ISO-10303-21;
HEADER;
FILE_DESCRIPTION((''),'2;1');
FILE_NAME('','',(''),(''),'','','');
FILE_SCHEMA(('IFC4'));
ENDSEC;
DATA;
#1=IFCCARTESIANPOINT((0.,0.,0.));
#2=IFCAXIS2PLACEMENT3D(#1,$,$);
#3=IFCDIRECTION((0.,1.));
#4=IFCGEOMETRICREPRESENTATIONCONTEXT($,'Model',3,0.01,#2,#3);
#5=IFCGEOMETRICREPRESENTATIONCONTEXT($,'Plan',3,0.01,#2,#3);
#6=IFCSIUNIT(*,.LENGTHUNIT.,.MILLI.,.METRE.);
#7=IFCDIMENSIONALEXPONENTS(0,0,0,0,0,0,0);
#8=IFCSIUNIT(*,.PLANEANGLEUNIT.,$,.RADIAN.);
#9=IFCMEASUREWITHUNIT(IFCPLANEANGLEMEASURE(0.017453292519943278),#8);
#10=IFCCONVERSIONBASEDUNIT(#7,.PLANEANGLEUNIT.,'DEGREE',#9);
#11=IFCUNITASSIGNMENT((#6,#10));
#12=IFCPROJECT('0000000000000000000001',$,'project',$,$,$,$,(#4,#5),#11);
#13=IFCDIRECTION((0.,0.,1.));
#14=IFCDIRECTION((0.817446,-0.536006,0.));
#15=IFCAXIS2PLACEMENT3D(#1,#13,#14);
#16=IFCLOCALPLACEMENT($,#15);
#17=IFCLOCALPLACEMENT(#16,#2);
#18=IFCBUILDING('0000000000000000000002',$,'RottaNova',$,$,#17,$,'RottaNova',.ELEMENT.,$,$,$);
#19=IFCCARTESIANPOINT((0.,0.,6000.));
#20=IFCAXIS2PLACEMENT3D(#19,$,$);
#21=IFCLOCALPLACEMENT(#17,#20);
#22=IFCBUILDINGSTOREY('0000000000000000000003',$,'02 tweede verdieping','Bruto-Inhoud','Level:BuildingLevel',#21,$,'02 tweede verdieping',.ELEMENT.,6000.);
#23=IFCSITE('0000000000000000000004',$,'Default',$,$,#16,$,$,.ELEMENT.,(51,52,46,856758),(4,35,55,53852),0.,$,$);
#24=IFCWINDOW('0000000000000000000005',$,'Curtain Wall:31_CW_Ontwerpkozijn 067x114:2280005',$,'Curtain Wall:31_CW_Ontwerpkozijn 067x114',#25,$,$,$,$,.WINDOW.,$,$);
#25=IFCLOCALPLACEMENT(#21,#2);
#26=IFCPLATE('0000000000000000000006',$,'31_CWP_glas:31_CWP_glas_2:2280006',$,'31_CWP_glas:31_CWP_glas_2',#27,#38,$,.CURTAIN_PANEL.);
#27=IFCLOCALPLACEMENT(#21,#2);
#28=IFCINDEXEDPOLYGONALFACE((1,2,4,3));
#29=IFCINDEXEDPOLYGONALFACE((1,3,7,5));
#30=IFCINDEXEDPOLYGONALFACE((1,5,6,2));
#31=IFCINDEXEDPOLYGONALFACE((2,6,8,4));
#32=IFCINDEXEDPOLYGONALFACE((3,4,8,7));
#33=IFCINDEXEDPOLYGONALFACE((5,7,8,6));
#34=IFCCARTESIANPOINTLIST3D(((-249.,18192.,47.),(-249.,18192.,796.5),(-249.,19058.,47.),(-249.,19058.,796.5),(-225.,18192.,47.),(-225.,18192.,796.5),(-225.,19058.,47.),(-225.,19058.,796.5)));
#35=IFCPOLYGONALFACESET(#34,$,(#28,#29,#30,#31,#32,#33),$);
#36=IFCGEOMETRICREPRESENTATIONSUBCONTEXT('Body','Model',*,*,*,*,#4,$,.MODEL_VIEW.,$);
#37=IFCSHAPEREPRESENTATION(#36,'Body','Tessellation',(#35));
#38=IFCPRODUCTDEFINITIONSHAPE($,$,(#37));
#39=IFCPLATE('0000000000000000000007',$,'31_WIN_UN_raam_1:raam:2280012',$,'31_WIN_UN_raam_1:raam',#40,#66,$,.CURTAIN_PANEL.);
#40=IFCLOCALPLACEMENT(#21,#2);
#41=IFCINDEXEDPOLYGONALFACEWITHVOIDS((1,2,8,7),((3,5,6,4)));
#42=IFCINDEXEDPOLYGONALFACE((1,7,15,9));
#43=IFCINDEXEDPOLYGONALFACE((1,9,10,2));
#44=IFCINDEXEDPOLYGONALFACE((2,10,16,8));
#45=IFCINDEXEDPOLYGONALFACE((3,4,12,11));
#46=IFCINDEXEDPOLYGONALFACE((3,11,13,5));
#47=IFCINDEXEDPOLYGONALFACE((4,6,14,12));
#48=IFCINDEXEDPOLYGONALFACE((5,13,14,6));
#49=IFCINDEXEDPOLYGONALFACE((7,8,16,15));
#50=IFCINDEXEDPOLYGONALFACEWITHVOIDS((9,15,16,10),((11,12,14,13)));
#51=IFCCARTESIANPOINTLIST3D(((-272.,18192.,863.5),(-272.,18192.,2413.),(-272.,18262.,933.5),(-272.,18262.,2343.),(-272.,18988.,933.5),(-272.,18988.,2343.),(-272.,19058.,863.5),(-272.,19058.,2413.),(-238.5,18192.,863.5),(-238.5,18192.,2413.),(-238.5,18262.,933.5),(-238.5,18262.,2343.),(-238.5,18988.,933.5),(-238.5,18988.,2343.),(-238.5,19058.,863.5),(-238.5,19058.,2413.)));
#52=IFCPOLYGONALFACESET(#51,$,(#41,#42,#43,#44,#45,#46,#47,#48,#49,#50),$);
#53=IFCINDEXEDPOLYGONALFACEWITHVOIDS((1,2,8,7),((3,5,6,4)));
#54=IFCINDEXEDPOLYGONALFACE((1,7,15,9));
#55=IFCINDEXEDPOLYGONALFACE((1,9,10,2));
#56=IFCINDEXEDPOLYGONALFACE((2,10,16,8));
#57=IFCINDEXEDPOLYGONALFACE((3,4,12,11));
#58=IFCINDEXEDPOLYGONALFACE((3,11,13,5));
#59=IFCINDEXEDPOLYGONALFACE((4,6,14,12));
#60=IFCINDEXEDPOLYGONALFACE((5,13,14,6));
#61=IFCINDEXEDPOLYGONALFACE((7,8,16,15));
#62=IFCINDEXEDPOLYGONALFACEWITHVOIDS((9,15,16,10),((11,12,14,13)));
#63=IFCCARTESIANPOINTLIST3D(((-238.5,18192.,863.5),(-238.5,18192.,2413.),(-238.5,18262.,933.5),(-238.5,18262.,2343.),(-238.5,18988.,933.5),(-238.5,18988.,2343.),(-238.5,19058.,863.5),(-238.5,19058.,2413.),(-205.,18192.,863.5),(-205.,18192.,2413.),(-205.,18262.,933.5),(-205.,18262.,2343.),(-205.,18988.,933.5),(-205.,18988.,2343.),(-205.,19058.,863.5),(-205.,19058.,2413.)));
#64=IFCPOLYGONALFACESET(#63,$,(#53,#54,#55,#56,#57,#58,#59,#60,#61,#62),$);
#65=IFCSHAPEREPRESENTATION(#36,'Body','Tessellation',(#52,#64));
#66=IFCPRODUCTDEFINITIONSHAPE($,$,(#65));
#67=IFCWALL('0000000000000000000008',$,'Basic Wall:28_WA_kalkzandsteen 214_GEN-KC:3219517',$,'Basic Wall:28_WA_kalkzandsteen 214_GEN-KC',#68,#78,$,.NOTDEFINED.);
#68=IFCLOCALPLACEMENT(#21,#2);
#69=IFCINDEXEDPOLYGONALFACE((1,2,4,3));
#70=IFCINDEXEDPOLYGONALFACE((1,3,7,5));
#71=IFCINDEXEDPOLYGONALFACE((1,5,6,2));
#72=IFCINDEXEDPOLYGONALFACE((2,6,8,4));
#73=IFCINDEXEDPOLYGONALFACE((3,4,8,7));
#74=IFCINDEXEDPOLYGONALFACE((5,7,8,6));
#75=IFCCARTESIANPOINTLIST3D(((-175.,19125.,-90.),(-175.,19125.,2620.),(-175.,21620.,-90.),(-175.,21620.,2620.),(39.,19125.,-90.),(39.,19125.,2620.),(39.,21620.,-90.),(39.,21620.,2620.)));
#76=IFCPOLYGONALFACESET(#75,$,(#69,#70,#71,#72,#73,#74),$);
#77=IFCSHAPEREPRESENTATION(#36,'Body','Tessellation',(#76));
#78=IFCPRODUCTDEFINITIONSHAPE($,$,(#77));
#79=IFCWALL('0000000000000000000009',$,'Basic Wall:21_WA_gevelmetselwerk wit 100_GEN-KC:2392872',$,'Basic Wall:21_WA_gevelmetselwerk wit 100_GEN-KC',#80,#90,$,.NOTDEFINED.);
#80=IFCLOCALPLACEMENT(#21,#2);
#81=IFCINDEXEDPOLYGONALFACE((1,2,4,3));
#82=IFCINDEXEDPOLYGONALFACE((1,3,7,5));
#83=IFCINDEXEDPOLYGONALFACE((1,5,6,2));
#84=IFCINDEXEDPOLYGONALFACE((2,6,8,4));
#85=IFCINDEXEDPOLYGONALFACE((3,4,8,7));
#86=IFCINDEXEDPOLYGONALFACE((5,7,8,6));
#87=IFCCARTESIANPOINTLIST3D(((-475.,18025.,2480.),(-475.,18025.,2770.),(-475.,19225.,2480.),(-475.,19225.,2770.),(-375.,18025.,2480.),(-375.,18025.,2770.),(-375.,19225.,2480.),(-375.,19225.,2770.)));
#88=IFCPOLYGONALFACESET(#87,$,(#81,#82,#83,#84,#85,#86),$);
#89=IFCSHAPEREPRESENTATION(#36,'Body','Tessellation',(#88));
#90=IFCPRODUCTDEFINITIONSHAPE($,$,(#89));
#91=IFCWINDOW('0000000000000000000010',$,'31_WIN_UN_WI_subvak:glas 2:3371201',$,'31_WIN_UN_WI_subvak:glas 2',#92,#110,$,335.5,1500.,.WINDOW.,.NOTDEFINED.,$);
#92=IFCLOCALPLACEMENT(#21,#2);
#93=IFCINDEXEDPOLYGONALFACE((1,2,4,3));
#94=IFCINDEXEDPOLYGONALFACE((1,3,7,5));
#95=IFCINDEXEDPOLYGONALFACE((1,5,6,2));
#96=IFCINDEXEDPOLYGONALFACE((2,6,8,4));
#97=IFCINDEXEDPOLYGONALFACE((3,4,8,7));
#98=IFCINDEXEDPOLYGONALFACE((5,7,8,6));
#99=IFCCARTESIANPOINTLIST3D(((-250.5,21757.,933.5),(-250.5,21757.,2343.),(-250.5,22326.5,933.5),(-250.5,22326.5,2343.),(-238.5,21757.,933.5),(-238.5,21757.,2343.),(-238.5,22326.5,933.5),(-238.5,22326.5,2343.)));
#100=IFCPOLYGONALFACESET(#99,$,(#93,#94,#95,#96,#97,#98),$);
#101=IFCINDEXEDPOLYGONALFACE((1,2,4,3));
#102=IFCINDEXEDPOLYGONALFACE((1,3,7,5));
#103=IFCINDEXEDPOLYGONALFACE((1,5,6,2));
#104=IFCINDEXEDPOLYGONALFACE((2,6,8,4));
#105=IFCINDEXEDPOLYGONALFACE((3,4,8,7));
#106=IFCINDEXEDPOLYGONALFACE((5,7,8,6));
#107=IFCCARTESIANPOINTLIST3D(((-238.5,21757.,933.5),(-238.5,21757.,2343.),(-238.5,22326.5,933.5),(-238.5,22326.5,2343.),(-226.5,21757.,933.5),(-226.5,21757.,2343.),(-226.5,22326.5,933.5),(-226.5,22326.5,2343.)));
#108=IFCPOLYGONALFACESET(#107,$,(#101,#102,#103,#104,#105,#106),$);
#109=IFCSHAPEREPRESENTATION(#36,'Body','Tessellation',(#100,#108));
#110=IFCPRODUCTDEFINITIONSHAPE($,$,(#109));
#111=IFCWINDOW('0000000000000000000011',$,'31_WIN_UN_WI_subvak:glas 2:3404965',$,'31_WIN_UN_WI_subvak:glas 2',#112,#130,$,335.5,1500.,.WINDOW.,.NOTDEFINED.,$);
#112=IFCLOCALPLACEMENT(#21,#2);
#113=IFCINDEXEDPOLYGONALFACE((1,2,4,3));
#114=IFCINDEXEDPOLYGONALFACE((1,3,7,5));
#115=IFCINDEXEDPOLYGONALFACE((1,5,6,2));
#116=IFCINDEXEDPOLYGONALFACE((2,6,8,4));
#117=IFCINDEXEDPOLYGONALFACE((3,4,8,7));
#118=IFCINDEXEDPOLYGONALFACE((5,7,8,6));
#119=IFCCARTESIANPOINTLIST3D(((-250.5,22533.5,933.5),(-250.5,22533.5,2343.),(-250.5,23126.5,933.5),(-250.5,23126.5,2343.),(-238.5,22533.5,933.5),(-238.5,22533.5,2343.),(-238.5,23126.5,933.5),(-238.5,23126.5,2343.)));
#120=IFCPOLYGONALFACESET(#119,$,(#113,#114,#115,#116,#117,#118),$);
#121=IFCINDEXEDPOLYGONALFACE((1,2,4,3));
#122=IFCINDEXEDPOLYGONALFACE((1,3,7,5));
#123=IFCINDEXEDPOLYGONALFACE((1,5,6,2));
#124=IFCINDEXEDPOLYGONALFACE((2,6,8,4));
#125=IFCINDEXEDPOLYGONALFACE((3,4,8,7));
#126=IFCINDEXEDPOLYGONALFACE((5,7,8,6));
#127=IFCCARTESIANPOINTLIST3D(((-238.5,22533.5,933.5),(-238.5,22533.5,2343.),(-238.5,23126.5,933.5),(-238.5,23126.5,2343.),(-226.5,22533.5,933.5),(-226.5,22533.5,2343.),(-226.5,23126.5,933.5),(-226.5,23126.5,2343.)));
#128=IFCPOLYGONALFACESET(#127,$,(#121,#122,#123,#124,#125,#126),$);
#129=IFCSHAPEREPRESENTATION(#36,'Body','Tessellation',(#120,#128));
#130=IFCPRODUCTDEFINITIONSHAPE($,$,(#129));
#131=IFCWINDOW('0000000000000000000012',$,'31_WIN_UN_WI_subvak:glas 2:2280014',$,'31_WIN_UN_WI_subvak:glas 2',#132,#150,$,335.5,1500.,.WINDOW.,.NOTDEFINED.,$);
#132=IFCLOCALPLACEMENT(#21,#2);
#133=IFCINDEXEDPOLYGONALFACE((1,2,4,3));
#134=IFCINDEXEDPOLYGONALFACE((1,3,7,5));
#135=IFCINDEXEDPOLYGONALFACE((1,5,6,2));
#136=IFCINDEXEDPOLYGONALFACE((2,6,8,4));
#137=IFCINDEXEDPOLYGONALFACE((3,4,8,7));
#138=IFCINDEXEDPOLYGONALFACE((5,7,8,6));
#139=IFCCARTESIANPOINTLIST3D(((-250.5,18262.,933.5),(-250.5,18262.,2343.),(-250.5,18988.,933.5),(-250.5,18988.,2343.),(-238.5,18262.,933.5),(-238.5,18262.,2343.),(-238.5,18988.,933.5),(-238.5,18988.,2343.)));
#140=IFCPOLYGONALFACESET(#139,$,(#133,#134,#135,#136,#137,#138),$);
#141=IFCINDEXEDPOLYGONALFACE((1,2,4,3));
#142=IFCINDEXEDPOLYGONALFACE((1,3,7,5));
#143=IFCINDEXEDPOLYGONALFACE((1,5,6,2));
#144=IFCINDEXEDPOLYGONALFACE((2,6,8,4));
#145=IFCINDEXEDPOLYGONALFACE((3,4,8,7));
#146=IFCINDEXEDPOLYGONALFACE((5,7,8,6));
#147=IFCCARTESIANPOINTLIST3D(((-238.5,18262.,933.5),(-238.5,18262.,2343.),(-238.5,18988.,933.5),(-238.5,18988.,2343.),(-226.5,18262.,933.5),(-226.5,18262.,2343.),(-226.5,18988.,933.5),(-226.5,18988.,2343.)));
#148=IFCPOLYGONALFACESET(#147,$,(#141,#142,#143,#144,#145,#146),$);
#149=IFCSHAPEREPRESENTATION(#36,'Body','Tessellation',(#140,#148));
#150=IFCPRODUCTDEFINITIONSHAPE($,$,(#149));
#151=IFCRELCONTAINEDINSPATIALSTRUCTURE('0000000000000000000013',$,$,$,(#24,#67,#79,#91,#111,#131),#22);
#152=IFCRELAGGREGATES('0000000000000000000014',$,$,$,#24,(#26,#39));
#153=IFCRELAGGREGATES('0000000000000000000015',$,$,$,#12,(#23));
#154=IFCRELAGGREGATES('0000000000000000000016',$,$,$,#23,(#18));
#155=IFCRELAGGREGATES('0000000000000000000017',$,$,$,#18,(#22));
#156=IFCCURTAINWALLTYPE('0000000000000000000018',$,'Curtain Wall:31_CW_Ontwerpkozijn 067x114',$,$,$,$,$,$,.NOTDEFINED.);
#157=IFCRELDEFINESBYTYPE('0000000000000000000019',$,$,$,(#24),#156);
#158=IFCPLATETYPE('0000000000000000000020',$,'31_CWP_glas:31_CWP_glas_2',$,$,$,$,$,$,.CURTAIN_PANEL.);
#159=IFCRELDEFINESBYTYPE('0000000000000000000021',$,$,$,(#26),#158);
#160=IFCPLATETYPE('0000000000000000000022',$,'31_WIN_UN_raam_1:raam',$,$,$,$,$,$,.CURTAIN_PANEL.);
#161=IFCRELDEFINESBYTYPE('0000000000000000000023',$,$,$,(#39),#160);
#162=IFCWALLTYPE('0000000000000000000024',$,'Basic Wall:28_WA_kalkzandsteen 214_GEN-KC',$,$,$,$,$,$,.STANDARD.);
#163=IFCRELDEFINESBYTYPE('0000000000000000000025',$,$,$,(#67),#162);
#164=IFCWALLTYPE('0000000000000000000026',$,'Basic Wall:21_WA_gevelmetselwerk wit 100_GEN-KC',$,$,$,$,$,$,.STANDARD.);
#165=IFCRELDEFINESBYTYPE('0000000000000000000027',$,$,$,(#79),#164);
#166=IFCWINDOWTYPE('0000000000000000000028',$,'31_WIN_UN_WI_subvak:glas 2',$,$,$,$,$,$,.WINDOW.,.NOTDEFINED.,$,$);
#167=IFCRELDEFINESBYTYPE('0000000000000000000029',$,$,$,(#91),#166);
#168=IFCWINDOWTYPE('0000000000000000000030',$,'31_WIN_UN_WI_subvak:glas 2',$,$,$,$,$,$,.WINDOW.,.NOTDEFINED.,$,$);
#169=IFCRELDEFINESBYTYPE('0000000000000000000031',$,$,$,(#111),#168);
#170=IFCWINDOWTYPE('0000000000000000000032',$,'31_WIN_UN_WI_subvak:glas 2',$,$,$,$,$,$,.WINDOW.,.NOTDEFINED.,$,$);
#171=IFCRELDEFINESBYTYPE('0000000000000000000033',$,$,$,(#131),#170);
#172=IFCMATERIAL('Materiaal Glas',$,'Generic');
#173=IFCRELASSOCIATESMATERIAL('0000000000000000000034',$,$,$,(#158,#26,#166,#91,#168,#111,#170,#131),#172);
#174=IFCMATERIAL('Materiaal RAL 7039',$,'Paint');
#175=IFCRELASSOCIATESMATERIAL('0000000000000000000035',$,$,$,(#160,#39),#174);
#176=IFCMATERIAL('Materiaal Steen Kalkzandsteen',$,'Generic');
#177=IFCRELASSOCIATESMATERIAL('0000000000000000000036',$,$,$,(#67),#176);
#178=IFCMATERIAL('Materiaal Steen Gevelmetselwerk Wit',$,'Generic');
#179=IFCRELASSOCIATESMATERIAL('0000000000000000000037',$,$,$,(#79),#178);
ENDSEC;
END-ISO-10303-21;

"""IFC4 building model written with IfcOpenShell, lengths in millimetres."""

from ifc_helpers import new_model, entity, si_unit, converted_unit, direction, frame, origin, place, context, subcontext, project, spatial, indexed_curve, outline, extrude, source, transform, mapped, material, type_object, type_shapes, element, aggregate, save


model = new_model("IFC4")

# Units and contexts
model_context = context("Model", 3, precision=0.01, world=origin(), true_north=direction((0.0, 1.0)))
plan_context = context("Plan", 3, precision=0.01, world=origin(), true_north=direction((0.0, 1.0)))
body_context = subcontext(model_context, "Body", "Model", "MODEL_VIEW")
ifc_project = project(units=[si_unit("LENGTHUNIT", "METRE", prefix="MILLI"), converted_unit("PLANEANGLEUNIT", "DEGREE", entity("IfcPlaneAngleMeasure", 0.017453292519943278), si_unit("PLANEANGLEUNIT", "RADIAN"), dimensions=[0, 0, 0, 0, 0, 0, 0])], contexts=[model_context, plan_context])

# Site, building, storey
site_placement = place(None, frame((0.0, 0.0, 0.0), z_axis=(0.0, 0.0, 1.0), x_axis=(0.817446, -0.536006, 0.0)))
site = spatial("IfcSite", under=ifc_project, at=site_placement, Name="Default", CompositionType="ELEMENT", RefLatitude=(51, 52, 46, 856758), RefLongitude=(4, 35, 55, 53852), RefElevation=0.0)
building_placement = place(site_placement, origin())
building = spatial("IfcBuilding", under=site, at=building_placement, Name="RottaNova", LongName="RottaNova", CompositionType="ELEMENT")
storey_placement = place(building_placement, frame((0.0, 0.0, 6000.0)))
storey = spatial("IfcBuildingStorey", under=building, at=storey_placement, Name="02 tweede verdieping", Description="Bruto-Inhoud", ObjectType="Level:BuildingLevel", LongName="02 tweede verdieping", CompositionType="ELEMENT", Elevation=6000.0)

# Window
curtain_wall_type = type_object("IfcCurtainWallType", Name="Curtain Wall:31_CW_Ontwerpkozijn 067x114", PredefinedType="NOTDEFINED")
window_1_placement = place(storey_placement, frame((0.0, 0.0, -6000.0)))
window_1 = element("IfcWindow", 1, at=window_1_placement, inside=storey, type_object=curtain_wall_type, Name="Curtain Wall:31_CW_Ontwerpkozijn 067x114:2280005", ObjectType="Curtain Wall:31_CW_Ontwerpkozijn 067x114", PredefinedType="WINDOW")

# Plates
ifc_material_1 = material(Name="Materiaal Glas", Category="Generic")
ifc_material_2 = material(Name="Materiaal RAL 7039", Category="Paint")
plate_type_1 = type_object("IfcPlateType", Name="31_CWP_glas:31_CWP_glas_2", PredefinedType="CURTAIN_PANEL", material=ifc_material_1)
shared_shape_1 = source(origin(), body_context, "Body", "SweptSolid", [
    extrude(outline(indexed_curve([(-12.0, -433.0), (12.0, -433.0), (12.0, 433.0), (-12.0, 433.0), (-12.0, -433.0)], self_intersect=False)), frame((0.0, 57.0, 0.0), z_axis=(0.0, 0.0, 1.0), x_axis=(0.0, 1.0, 0.0)), (0.0, 0.0, 1.0), 749.5),
])
type_shapes(plate_type_1, [shared_shape_1])
plate_1_placement = place(window_1_placement, frame((-180.0, 18625.0, 6047.0), z_axis=(0.0, 0.0, 1.0), x_axis=(0.0, 1.0, 0.0)))
plate_1 = element("IfcPlate", 2, at=plate_1_placement, type_object=plate_type_1, material=ifc_material_1, Name="31_CWP_glas:31_CWP_glas_2:2280006", ObjectType="31_CWP_glas:31_CWP_glas_2", PredefinedType="CURTAIN_PANEL", context=body_context, shape_type="MappedRepresentation", body=[
    mapped(shared_shape_1, transform((0.0, 0.0, 0.0), scale=1.0)),
])
plate_type_2 = type_object("IfcPlateType", Name="31_WIN_UN_raam_1:raam", PredefinedType="CURTAIN_PANEL", material=ifc_material_2)
shared_shape_2 = source(origin(), body_context, "Body", "SweptSolid", [
    extrude(outline(indexed_curve([(-433.0, -774.7), (433.0, -774.7), (433.0, 774.7), (-433.0, 774.7), (-433.0, -774.7)], self_intersect=False), holes=[indexed_curve([(-363.0, 704.7), (363.0, 704.7), (363.0, -704.8), (-363.0, -704.8), (-363.0, 704.7)], self_intersect=False)]), frame((0.0, 58.5, 774.8), z_axis=(0.0, 1.0, 0.0), x_axis=(1.0, 0.0, 0.0)), (0.0, 0.0, 1.0), 33.5),
    extrude(outline(indexed_curve([(-433.0, -774.7), (433.0, -774.7), (433.0, 774.7), (-433.0, 774.7), (-433.0, -774.7)], self_intersect=False), holes=[indexed_curve([(-363.0, 704.7), (363.0, 704.7), (363.0, -704.8), (-363.0, -704.8), (-363.0, 704.7)], self_intersect=False)]), frame((0.0, 25.0, 774.8), z_axis=(0.0, 1.0, 0.0), x_axis=(1.0, 0.0, 0.0)), (0.0, 0.0, 1.0), 33.5),
])
type_shapes(plate_type_2, [shared_shape_2])
plate_2_placement = place(window_1_placement, frame((-180.0, 18625.0, 6863.5), z_axis=(0.0, 0.0, 1.0), x_axis=(0.0, 1.0, 0.0)))
plate_2 = element("IfcPlate", 3, at=plate_2_placement, type_object=plate_type_2, material=ifc_material_2, Name="31_WIN_UN_raam_1:raam:2280012", ObjectType="31_WIN_UN_raam_1:raam", PredefinedType="CURTAIN_PANEL", context=body_context, shape_type="MappedRepresentation", body=[
    mapped(shared_shape_2, transform((0.0, 0.0, 0.0), scale=1.0)),
])
aggregate(window_1, [plate_1, plate_2])

# Walls
ifc_material_3 = material(Name="Materiaal Steen Kalkzandsteen", Category="Generic")
wall_type_1 = type_object("IfcWallType", Name="Basic Wall:28_WA_kalkzandsteen 214_GEN-KC", PredefinedType="STANDARD")
wall_1_placement = place(storey_placement, frame((-68.0, 19125.0, -90.0), z_axis=(0.0, 0.0, 1.0), x_axis=(0.0, 1.0, 0.0)))
element("IfcWall", 4, at=wall_1_placement, inside=storey, type_object=wall_type_1, material=ifc_material_3, Name="Basic Wall:28_WA_kalkzandsteen 214_GEN-KC:3219517", ObjectType="Basic Wall:28_WA_kalkzandsteen 214_GEN-KC", PredefinedType="NOTDEFINED", context=body_context, shape_type="SweptSolid", body=[
    extrude(outline(indexed_curve([(2495.0, 107.0), (0.0, 107.0), (0.0, -107.0), (2495.0, -107.0), (2495.0, 107.0)], self_intersect=False)), origin(), (0.0, 0.0, 1.0), 2710.0),
])
ifc_material_4 = material(Name="Materiaal Steen Gevelmetselwerk Wit", Category="Generic")
wall_type_2 = type_object("IfcWallType", Name="Basic Wall:21_WA_gevelmetselwerk wit 100_GEN-KC", PredefinedType="STANDARD")
wall_2_placement = place(storey_placement, frame((-425.0, 19225.0, 2480.0), z_axis=(0.0, 0.0, 1.0), x_axis=(0.0, -1.0, 0.0)))
element("IfcWall", 5, at=wall_2_placement, inside=storey, type_object=wall_type_2, material=ifc_material_4, Name="Basic Wall:21_WA_gevelmetselwerk wit 100_GEN-KC:2392872", ObjectType="Basic Wall:21_WA_gevelmetselwerk wit 100_GEN-KC", PredefinedType="NOTDEFINED", context=body_context, shape_type="SweptSolid", body=[
    extrude(outline(indexed_curve([(1200.0, 50.0), (0.0, 50.0), (0.0, -50.0), (1200.0, -50.0), (1200.0, 50.0)], self_intersect=False)), origin(), (0.0, 0.0, 1.0), 290.0),
])

# Windows
window_type_1 = type_object("IfcWindowType", Name="31_WIN_UN_WI_subvak:glas 2", PartitioningType="NOTDEFINED", PredefinedType="WINDOW", material=ifc_material_1)
shared_shape_3 = source(origin(), body_context, "Body", "SweptSolid", [
    extrude(outline(indexed_curve([(-284.7, -6.0), (284.7, -6.0), (284.7, 6.0), (-284.7, 6.0), (-284.7, -6.0)], self_intersect=False)), frame((0.0, -6.0, 0.0)), (0.0, 0.0, 1.0), 1409.5),
    extrude(outline(indexed_curve([(-284.8, -6.0), (284.8, -6.0), (284.8, 6.0), (-284.8, 6.0), (-284.8, -6.0)], self_intersect=False)), frame((0.0, 6.0, 0.0)), (0.0, 0.0, 1.0), 1409.5),
])
type_shapes(window_type_1, [shared_shape_3])
window_2_placement = place(storey_placement, frame((-238.5, 22041.7, 933.5), z_axis=(0.0, 0.0, 1.0), x_axis=(0.0, -1.0, 0.0)))
element("IfcWindow", 6, at=window_2_placement, inside=storey, type_object=window_type_1, material=ifc_material_1, Name="31_WIN_UN_WI_subvak:glas 2:3371201", ObjectType="31_WIN_UN_WI_subvak:glas 2", OverallHeight=335.5, OverallWidth=1500.0, PartitioningType="NOTDEFINED", PredefinedType="WINDOW", context=body_context, shape_type="MappedRepresentation", body=[
    mapped(shared_shape_3, transform((0.0, 0.0, 0.0), scale=1.0)),
])
window_type_2 = type_object("IfcWindowType", Name="31_WIN_UN_WI_subvak:glas 2", PartitioningType="NOTDEFINED", PredefinedType="WINDOW", material=ifc_material_1)
shared_shape_4 = source(origin(), body_context, "Body", "SweptSolid", [
    extrude(outline(indexed_curve([(-296.5, -6.0), (296.5, -6.0), (296.5, 6.0), (-296.5, 6.0), (-296.5, -6.0)], self_intersect=False)), frame((0.0, -6.0, 0.0)), (0.0, 0.0, 1.0), 1409.5),
    extrude(outline(indexed_curve([(-296.5, -6.0), (296.5, -6.0), (296.5, 6.0), (-296.5, 6.0), (-296.5, -6.0)], self_intersect=False)), frame((0.0, 6.0, 0.0)), (0.0, 0.0, 1.0), 1409.5),
])
type_shapes(window_type_2, [shared_shape_4])
window_3_placement = place(storey_placement, frame((-238.5, 22830.0, 933.5), z_axis=(0.0, 0.0, 1.0), x_axis=(0.0, -1.0, 0.0)))
element("IfcWindow", 7, at=window_3_placement, inside=storey, type_object=window_type_2, material=ifc_material_1, Name="31_WIN_UN_WI_subvak:glas 2:3404965", ObjectType="31_WIN_UN_WI_subvak:glas 2", OverallHeight=335.5, OverallWidth=1500.0, PartitioningType="NOTDEFINED", PredefinedType="WINDOW", context=body_context, shape_type="MappedRepresentation", body=[
    mapped(shared_shape_4, transform((0.0, 0.0, 0.0), scale=1.0)),
])
window_type_3 = type_object("IfcWindowType", Name="31_WIN_UN_WI_subvak:glas 2", PartitioningType="NOTDEFINED", PredefinedType="WINDOW", material=ifc_material_1)
shared_shape_5 = source(origin(), body_context, "Body", "SweptSolid", [
    extrude(outline(indexed_curve([(-6.0, -363.0), (6.0, -363.0), (6.0, 363.0), (-6.0, 363.0), (-6.0, -363.0)], self_intersect=False)), frame((0.0, 6.0, 0.0), z_axis=(0.0, 0.0, 1.0), x_axis=(0.0, -1.0, 0.0)), (0.0, 0.0, 1.0), 1409.5),
    extrude(outline(indexed_curve([(-6.0, -363.0), (6.0, -363.0), (6.0, 363.0), (-6.0, 363.0), (-6.0, -363.0)], self_intersect=False)), frame((0.0, -6.0, 0.0), z_axis=(0.0, 0.0, 1.0), x_axis=(0.0, -1.0, 0.0)), (0.0, 0.0, 1.0), 1409.5),
])
type_shapes(window_type_3, [shared_shape_5])
window_4_placement = place(storey_placement, frame((-238.5, 18625.0, 933.5), z_axis=(0.0, 0.0, 1.0), x_axis=(0.0, 1.0, 0.0)))
element("IfcWindow", 8, at=window_4_placement, inside=storey, type_object=window_type_3, material=ifc_material_1, Name="31_WIN_UN_WI_subvak:glas 2:2280014", ObjectType="31_WIN_UN_WI_subvak:glas 2", OverallHeight=335.5, OverallWidth=1500.0, PartitioningType="NOTDEFINED", PredefinedType="WINDOW", context=body_context, shape_type="MappedRepresentation", body=[
    mapped(shared_shape_5, transform((0.0, 0.0, 0.0), scale=1.0)),
])

save(model, "model.ifc")
